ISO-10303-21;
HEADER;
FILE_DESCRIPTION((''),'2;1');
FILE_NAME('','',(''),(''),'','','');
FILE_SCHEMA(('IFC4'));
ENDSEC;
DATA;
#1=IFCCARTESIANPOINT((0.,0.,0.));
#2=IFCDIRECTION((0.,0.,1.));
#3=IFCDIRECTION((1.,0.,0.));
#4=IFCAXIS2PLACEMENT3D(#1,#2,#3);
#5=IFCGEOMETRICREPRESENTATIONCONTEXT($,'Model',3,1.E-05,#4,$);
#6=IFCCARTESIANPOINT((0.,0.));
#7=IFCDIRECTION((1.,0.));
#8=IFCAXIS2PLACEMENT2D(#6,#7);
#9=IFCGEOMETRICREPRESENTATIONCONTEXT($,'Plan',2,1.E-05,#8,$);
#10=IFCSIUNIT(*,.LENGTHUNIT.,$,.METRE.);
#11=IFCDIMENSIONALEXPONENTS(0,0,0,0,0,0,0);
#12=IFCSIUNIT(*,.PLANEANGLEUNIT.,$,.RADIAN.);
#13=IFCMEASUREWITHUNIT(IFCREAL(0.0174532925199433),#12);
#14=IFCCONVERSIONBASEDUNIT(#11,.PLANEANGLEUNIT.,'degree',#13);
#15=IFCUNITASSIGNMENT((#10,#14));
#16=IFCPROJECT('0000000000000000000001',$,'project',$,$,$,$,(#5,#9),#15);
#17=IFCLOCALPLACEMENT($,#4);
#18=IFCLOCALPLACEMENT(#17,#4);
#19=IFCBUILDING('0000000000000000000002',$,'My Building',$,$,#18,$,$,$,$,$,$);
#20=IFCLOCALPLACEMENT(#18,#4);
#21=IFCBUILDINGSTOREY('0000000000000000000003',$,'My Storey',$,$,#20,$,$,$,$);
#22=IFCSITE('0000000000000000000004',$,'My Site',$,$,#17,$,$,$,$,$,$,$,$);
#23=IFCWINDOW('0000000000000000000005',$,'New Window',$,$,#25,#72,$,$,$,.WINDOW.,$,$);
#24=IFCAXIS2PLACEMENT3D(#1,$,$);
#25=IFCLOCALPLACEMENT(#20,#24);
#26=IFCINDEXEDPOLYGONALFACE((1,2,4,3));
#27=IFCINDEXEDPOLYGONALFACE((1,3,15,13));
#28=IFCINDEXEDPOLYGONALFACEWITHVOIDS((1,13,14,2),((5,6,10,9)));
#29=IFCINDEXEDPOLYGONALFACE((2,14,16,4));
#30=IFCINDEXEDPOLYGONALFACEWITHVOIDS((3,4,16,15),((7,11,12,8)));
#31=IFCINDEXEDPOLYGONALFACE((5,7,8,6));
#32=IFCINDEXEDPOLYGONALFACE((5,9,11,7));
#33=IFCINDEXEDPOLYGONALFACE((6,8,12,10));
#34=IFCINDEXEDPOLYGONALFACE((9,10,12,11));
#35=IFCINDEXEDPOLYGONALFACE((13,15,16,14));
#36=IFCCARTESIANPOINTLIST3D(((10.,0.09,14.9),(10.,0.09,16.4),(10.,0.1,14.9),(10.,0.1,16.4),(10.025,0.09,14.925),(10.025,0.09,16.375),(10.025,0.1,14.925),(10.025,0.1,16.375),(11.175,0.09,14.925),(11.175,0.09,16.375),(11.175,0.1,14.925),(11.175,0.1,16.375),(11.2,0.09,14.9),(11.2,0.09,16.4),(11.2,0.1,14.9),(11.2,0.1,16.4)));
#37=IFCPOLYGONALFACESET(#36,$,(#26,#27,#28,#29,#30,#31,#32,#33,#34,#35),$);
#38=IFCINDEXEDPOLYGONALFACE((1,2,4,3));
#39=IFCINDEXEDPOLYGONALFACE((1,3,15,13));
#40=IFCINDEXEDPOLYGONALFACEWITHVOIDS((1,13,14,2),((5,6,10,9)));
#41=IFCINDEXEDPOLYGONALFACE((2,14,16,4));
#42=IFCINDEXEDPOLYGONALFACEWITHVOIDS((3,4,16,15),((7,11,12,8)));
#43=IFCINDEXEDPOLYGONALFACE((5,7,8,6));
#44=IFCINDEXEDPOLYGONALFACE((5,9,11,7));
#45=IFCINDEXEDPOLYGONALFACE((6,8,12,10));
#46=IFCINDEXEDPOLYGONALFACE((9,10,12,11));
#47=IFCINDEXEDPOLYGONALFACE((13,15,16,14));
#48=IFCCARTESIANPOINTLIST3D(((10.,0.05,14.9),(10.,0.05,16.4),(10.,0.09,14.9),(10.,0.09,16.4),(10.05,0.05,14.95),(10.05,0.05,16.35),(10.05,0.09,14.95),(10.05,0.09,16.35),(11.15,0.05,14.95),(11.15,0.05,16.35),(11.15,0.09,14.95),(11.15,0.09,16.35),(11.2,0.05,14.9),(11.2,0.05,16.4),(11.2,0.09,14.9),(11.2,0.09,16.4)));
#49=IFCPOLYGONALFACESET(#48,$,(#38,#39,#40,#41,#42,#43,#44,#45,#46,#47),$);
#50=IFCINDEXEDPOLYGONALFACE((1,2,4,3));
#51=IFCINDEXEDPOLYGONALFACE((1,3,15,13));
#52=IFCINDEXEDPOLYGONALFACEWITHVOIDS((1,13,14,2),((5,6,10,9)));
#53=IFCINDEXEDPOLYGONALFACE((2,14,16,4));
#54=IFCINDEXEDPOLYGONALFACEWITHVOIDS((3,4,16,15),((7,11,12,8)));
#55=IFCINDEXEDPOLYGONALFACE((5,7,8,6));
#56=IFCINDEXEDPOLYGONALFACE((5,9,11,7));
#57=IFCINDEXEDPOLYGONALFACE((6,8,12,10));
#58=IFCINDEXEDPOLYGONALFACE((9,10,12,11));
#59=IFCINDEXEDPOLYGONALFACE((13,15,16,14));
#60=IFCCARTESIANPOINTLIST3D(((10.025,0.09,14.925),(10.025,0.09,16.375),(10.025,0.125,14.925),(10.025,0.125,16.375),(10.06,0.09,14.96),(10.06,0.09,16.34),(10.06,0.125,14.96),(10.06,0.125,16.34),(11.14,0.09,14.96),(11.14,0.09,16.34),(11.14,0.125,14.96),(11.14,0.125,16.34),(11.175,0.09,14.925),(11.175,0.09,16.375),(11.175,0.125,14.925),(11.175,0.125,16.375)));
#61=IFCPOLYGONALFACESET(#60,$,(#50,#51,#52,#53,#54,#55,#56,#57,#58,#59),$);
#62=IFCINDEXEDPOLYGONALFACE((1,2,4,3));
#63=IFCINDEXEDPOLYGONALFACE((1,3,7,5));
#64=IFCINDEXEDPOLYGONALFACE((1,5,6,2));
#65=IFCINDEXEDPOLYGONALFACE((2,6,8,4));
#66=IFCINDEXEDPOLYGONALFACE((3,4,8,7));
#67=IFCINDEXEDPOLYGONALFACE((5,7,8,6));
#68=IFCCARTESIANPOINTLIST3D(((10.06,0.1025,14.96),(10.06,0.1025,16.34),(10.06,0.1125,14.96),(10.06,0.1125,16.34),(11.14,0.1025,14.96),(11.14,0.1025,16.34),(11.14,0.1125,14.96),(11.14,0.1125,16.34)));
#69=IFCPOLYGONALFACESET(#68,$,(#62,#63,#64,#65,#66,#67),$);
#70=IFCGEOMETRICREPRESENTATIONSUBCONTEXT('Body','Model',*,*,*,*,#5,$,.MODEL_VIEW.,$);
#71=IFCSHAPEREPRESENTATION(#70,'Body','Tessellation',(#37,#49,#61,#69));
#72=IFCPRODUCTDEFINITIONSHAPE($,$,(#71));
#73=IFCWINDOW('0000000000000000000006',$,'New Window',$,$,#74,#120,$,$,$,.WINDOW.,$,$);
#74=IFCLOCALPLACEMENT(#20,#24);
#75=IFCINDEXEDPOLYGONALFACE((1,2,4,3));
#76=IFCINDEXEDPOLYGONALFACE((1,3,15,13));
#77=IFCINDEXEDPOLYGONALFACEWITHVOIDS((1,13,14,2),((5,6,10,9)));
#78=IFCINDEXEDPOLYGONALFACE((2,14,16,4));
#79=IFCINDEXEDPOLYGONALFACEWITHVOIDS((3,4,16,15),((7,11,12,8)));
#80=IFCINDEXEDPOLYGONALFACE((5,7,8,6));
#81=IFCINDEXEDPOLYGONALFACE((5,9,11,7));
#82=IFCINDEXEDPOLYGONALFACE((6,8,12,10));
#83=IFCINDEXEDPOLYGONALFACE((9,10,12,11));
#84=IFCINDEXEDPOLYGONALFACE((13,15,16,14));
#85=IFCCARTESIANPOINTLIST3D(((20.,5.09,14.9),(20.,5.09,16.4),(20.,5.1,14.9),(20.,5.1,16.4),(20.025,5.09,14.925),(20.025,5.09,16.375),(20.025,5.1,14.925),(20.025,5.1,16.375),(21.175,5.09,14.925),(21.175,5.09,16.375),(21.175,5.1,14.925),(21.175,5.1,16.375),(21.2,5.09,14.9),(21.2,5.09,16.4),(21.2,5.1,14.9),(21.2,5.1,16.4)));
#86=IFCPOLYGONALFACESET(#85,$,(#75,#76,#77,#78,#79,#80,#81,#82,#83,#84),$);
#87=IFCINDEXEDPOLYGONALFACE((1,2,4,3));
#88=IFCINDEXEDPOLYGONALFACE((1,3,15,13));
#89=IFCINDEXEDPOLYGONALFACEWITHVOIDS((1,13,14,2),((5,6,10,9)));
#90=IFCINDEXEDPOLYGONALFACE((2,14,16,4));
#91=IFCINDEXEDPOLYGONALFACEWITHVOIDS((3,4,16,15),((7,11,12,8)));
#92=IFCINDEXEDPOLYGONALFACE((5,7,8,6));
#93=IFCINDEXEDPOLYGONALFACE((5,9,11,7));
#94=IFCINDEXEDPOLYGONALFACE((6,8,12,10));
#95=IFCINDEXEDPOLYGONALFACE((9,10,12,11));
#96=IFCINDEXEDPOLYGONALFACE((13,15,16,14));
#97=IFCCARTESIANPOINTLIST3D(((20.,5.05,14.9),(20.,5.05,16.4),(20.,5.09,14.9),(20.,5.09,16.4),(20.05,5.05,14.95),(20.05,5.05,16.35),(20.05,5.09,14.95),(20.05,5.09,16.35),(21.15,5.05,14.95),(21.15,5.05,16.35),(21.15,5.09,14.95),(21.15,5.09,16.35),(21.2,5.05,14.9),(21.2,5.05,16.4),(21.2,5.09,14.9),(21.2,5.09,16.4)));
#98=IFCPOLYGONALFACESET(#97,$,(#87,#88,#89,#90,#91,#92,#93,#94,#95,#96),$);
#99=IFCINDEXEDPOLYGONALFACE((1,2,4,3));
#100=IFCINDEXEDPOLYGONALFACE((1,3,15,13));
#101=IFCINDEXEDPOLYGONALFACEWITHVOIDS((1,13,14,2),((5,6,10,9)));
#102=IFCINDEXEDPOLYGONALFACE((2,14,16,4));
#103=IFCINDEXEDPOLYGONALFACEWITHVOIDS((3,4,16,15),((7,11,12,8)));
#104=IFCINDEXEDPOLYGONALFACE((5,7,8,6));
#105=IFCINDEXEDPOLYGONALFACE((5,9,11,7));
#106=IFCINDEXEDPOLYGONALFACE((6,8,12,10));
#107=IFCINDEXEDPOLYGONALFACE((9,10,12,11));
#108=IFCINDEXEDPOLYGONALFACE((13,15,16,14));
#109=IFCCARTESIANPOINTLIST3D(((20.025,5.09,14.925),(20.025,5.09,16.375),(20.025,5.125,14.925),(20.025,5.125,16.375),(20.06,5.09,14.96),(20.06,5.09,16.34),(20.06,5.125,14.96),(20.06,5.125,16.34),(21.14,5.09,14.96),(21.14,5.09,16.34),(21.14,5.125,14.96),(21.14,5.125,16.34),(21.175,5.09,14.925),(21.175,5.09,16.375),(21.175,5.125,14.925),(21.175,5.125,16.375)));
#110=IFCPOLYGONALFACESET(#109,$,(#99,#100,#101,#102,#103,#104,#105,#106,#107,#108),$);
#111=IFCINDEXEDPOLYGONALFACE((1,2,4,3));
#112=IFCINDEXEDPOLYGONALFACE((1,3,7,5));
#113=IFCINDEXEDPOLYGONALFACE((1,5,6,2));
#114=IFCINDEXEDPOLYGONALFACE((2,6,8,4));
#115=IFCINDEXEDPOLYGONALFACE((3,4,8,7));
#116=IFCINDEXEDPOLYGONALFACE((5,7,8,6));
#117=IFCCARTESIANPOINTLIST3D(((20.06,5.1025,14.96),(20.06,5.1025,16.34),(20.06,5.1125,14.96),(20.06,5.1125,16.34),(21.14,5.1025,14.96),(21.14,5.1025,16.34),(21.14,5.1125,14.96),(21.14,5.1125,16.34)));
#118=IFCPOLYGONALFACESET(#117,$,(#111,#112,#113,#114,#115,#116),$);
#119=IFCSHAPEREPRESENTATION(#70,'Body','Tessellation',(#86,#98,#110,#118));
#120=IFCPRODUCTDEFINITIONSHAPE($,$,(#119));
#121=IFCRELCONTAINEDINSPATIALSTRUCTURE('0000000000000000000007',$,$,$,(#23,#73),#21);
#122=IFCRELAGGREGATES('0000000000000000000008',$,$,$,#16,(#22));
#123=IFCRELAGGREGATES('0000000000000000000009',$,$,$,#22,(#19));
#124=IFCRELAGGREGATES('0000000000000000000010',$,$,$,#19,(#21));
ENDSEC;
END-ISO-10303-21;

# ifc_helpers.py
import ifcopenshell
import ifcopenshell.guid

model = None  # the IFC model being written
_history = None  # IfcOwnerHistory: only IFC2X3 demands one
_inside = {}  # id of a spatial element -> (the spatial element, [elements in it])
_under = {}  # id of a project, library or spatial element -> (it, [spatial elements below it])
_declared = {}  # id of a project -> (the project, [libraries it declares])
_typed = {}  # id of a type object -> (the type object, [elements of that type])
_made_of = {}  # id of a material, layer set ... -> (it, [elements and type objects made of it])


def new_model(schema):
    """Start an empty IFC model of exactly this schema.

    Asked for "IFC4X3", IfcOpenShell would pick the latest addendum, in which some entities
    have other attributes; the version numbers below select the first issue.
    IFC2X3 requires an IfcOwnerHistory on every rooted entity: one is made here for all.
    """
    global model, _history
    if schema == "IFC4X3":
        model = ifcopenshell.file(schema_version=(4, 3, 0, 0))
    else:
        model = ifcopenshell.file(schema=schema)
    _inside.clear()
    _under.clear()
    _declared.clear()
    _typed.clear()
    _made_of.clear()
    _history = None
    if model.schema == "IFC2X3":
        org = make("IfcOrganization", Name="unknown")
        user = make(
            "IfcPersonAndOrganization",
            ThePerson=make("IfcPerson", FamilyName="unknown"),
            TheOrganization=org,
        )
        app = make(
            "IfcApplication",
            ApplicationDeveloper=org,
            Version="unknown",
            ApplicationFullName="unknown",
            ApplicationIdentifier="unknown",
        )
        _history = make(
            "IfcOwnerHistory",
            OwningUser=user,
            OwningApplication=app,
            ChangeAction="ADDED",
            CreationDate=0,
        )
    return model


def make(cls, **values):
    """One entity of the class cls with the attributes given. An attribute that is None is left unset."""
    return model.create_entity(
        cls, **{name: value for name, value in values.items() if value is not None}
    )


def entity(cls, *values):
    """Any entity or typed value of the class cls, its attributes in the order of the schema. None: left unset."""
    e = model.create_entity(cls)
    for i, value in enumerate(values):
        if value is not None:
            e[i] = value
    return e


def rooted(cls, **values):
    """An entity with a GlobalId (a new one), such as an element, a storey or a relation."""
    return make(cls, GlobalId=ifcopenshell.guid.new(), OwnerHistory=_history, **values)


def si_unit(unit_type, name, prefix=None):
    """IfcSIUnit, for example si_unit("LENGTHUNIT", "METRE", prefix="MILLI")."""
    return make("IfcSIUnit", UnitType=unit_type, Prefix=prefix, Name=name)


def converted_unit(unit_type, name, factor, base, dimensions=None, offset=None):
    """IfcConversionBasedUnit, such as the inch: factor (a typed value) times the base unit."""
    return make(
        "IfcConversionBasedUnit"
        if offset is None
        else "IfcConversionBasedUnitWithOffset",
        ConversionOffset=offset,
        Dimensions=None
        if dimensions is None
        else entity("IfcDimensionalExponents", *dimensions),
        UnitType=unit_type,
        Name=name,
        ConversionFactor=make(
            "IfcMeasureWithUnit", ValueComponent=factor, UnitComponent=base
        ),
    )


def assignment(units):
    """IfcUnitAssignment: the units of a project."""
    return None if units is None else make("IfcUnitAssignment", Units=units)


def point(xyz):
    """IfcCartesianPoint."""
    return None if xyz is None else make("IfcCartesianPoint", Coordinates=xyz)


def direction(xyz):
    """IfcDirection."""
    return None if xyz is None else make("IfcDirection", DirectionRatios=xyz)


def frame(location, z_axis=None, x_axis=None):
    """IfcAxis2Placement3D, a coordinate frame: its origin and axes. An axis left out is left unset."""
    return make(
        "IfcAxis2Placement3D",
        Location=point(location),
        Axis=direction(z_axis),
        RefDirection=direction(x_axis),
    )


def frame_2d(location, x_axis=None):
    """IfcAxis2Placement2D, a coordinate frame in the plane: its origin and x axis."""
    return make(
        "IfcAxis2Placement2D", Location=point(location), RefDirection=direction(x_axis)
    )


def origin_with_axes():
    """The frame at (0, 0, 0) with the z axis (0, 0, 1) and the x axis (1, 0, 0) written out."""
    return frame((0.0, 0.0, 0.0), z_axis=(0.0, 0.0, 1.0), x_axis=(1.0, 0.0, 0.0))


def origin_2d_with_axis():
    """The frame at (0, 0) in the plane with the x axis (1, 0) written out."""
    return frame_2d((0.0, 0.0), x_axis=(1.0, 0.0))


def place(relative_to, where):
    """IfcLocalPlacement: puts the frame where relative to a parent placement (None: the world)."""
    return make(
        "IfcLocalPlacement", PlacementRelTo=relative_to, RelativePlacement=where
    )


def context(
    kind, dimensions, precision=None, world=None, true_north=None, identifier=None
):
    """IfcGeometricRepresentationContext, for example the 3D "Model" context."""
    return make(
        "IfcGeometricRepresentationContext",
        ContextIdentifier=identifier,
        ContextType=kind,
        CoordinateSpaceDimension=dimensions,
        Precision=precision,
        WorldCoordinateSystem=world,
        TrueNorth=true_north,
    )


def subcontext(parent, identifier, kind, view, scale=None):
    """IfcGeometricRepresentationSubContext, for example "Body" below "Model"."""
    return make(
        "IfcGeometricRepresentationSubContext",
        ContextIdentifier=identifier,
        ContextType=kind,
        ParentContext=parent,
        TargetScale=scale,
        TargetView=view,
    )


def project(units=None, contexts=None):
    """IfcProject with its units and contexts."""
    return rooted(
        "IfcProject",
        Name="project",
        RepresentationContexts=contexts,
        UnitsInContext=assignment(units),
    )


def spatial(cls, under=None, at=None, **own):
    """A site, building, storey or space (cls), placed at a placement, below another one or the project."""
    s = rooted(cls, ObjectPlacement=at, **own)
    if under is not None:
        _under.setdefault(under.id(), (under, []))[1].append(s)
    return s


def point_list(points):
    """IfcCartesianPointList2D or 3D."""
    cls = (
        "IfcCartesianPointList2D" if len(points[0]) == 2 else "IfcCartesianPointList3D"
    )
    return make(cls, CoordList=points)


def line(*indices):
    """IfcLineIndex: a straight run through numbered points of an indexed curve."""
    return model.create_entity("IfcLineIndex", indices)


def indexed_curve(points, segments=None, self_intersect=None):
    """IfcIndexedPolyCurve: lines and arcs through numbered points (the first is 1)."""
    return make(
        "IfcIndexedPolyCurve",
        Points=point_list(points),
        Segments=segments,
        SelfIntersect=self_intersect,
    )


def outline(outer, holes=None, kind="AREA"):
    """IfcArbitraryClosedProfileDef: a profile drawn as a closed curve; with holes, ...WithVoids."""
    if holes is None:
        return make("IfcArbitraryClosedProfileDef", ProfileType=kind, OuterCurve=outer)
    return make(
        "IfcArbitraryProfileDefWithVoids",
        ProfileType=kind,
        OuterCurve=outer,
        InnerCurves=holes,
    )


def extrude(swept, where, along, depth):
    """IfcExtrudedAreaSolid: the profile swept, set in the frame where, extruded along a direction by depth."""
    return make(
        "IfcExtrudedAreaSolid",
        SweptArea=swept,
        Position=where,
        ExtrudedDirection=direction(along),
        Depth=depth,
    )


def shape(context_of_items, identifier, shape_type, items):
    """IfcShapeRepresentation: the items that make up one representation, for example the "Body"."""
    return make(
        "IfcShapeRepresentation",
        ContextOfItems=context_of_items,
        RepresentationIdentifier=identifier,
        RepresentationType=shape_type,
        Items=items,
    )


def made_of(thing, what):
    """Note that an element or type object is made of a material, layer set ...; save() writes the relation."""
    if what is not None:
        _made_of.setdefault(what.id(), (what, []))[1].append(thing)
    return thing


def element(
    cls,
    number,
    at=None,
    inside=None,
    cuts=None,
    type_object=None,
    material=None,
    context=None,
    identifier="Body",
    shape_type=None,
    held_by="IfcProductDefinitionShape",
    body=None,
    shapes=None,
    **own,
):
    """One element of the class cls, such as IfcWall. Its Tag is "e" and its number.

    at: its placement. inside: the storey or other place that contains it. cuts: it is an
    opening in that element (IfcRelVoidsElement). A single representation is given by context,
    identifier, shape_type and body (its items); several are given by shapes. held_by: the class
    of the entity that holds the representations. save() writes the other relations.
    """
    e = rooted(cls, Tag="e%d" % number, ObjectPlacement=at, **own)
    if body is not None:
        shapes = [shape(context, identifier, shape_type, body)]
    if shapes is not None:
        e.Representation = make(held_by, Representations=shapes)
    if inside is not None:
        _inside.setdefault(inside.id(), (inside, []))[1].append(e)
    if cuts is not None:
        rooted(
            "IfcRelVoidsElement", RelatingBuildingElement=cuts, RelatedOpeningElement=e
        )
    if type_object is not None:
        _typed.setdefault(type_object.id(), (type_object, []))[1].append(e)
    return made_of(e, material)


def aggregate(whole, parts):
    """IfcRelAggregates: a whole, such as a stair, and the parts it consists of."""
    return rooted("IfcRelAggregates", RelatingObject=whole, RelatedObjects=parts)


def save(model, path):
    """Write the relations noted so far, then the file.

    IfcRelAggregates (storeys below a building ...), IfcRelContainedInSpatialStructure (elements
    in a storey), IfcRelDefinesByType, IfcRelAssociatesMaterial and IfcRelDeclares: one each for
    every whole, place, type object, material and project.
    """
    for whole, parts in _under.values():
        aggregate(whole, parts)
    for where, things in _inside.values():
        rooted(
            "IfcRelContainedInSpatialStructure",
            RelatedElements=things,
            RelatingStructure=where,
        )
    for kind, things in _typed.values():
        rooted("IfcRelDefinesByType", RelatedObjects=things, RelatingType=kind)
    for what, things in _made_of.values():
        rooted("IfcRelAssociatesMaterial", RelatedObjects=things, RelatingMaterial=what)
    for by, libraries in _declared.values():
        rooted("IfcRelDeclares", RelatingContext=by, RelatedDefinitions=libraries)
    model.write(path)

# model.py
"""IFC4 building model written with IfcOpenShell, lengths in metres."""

from ifc_helpers import new_model, entity, si_unit, converted_unit, frame, origin_with_axes, origin_2d_with_axis, place, context, subcontext, project, spatial, line, indexed_curve, outline, extrude, element, save


model = new_model("IFC4")

# Units and contexts
model_context = context("Model", 3, precision=1e-05, world=origin_with_axes())
plan_context = context("Plan", 2, precision=1e-05, world=origin_2d_with_axis())
body_context = subcontext(model_context, "Body", "Model", "MODEL_VIEW")
ifc_project = project(units=[si_unit("LENGTHUNIT", "METRE"), converted_unit("PLANEANGLEUNIT", "degree", entity("IfcReal", 0.0174532925199433), si_unit("PLANEANGLEUNIT", "RADIAN"), dimensions=[0, 0, 0, 0, 0, 0, 0])], contexts=[model_context, plan_context])

# Site, building, storey
site_placement = place(None, origin_with_axes())
site = spatial("IfcSite", under=ifc_project, at=site_placement, Name="My Site")
building_placement = place(site_placement, origin_with_axes())
building = spatial("IfcBuilding", under=site, at=building_placement, Name="My Building")
storey_placement = place(building_placement, origin_with_axes())
storey = spatial("IfcBuildingStorey", under=building, at=storey_placement, Name="My Storey")

# Windows
for number, where, z_axis, x_axis, name in (
    (1, (10.0, 0.0, 14.9), (0.0, 0.0, 1.0), (1.0, 0.0, 0.0), "New Window"),
    (2, (20.0, 5.0, 14.9), (0.0, 0.0, 1.0), (1.0, 0.0, 0.0), "New Window"),
):
    element("IfcWindow", number, at=place(storey_placement, frame(where, z_axis=z_axis, x_axis=x_axis)), inside=storey, Name=name, PredefinedType="WINDOW", context=body_context, shape_type="SweptSolid", body=[
        extrude(outline(indexed_curve([(0.0, 0.0), (1.2, 0.0), (1.2, 1.5), (0.0, 1.5)], segments=[line(1, 2, 3, 4, 1)]), holes=[indexed_curve([(0.025, 0.025), (1.175, 0.025), (1.175, 1.475), (0.025, 1.475)], segments=[line(1, 2, 3, 4, 1)])]), frame((0.0, 0.09, 0.0), z_axis=(0.0, -1.0, 0.0), x_axis=(1.0, 0.0, 0.0)), (0.0, 0.0, -1.0), 0.01),
        extrude(outline(indexed_curve([(0.0, 0.0), (1.2, 0.0), (1.2, 1.5), (0.0, 1.5)], segments=[line(1, 2, 3, 4, 1)]), holes=[indexed_curve([(0.05, 0.05), (1.15, 0.05), (1.15, 1.45), (0.05, 1.45)], segments=[line(1, 2, 3, 4, 1)])]), frame((0.0, 0.05, 0.0), z_axis=(0.0, -1.0, 0.0), x_axis=(1.0, 0.0, 0.0)), (0.0, 0.0, -1.0), 0.04),
        extrude(outline(indexed_curve([(0.0, 0.0), (1.15, 0.0), (1.15, 1.45), (0.0, 1.45)], segments=[line(1, 2, 3, 4, 1)]), holes=[indexed_curve([(0.035, 0.035), (1.115, 0.035), (1.115, 1.415), (0.035, 1.415)], segments=[line(1, 2, 3, 4, 1)])]), frame((0.025, 0.09, 0.025), z_axis=(0.0, -1.0, 0.0), x_axis=(1.0, 0.0, 0.0)), (0.0, 0.0, -1.0), 0.035),
        extrude(outline(indexed_curve([(0.035, 0.035), (1.115, 0.035), (1.115, 1.415), (0.035, 1.415)], segments=[line(1, 2, 3, 4, 1)])), frame((0.025, 0.1025, 0.025), z_axis=(0.0, -1.0, 0.0), x_axis=(1.0, 0.0, 0.0)), (0.0, 0.0, -1.0), 0.01),
    ])

save(model, "model.ifc")
